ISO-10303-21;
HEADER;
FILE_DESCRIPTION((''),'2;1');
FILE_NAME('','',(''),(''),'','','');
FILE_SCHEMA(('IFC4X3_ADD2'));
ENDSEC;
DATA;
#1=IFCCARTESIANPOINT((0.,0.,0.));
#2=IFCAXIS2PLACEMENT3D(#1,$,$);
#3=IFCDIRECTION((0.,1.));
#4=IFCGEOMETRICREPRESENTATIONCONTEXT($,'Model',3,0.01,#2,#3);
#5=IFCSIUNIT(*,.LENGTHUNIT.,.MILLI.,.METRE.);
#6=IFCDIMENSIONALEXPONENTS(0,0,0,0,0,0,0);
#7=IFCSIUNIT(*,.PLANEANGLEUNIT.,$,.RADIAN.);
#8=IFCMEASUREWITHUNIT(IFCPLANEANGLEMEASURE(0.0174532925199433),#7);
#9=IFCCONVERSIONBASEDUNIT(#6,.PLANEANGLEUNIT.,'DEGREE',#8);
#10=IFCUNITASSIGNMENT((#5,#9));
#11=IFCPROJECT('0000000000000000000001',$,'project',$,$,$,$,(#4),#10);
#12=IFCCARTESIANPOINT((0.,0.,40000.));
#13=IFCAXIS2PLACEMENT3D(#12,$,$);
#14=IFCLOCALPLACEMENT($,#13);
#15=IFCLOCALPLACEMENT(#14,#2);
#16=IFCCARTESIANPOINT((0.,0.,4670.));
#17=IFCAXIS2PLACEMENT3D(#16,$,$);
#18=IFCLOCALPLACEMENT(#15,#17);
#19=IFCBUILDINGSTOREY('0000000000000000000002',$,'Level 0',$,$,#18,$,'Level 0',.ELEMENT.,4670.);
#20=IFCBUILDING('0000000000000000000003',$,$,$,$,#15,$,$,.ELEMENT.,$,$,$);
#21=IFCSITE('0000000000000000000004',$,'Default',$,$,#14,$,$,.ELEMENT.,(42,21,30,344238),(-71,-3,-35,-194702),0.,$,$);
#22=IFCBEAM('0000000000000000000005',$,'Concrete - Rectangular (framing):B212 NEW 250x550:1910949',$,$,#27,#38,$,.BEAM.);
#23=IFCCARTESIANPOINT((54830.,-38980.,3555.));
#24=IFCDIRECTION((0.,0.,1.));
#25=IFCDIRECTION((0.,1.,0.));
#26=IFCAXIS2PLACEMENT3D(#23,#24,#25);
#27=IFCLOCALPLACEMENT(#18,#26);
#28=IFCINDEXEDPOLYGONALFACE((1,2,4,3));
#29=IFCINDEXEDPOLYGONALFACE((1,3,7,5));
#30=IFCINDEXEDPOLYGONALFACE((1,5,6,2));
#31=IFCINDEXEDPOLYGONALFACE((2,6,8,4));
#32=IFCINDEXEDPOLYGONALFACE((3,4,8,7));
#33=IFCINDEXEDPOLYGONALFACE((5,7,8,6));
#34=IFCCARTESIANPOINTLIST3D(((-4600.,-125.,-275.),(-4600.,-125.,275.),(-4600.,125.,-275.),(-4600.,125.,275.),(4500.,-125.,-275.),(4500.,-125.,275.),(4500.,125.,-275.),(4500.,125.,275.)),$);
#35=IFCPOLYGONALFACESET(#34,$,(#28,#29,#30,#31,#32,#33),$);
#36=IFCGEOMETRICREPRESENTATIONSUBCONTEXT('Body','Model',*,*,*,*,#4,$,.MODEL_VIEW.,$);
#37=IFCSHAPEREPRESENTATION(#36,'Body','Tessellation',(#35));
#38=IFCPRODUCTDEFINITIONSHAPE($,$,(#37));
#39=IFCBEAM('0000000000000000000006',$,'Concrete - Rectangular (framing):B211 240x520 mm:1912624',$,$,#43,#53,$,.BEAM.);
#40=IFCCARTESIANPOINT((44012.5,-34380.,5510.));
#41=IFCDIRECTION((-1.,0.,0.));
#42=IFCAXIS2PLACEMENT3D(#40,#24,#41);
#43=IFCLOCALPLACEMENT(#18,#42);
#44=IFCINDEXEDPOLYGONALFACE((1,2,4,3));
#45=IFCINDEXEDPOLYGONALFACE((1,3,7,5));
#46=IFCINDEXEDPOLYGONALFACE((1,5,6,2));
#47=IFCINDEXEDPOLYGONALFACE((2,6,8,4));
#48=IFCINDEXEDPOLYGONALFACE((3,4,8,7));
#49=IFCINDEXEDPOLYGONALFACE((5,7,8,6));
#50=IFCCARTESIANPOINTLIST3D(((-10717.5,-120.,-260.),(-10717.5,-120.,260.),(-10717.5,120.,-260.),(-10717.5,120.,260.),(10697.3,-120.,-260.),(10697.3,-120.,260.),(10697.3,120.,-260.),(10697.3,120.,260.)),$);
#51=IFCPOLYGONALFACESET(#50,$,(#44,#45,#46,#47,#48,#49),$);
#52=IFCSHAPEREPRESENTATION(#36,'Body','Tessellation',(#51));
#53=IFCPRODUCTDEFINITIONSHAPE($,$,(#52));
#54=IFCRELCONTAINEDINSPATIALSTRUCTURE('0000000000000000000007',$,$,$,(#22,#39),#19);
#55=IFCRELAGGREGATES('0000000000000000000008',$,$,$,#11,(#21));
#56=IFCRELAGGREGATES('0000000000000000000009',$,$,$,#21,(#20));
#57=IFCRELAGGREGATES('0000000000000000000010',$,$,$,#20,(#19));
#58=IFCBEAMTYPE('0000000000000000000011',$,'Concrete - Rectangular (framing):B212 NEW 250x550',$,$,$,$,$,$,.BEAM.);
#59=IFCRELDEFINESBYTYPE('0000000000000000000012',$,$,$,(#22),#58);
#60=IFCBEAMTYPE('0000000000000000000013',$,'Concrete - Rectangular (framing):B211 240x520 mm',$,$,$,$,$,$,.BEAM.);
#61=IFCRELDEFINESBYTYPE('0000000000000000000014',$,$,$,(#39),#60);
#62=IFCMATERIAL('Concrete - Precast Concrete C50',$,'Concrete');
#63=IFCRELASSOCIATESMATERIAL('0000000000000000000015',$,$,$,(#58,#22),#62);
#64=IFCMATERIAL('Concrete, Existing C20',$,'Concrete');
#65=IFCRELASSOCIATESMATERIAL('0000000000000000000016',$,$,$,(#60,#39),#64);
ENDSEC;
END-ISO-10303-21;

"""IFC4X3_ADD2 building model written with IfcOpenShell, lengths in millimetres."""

from ifc_helpers import new_model, entity, si_unit, converted_unit, direction, frame, origin, origin_2d_with_axis, place, context, subcontext, project, spatial, rectangle, extrude, source, transform, mapped, material, material_profile, profile_set, profile_usage, type_object, type_shapes, element, save


model = new_model("IFC4X3_ADD2")

# Units and contexts
model_context = context("Model", 3, precision=0.01, world=origin(), true_north=direction((0.0, 1.0)))
body_context = subcontext(model_context, "Body", "Model", "MODEL_VIEW")
ifc_project = project(units=[si_unit("LENGTHUNIT", "METRE", prefix="MILLI"), converted_unit("PLANEANGLEUNIT", "DEGREE", entity("IfcPlaneAngleMeasure", 0.0174532925199433), si_unit("PLANEANGLEUNIT", "RADIAN"), dimensions=[0, 0, 0, 0, 0, 0, 0])], contexts=[model_context])

# Site, building, storey
site_placement = place(None, frame((0.0, 0.0, 40000.0)))
site = spatial("IfcSite", under=ifc_project, at=site_placement, Name="Default", CompositionType="ELEMENT", RefLatitude=(42, 21, 30, 344238), RefLongitude=(-71, -3, -35, -194702), RefElevation=0.0)
building_placement = place(site_placement, origin())
building = spatial("IfcBuilding", under=site, at=building_placement, CompositionType="ELEMENT")
storey_placement = place(building_placement, frame((0.0, 0.0, 4670.0)))
storey = spatial("IfcBuildingStorey", under=building, at=storey_placement, Name="Level 0", LongName="Level 0", CompositionType="ELEMENT", Elevation=4670.0)

# Beams
ifc_material_1 = material(Name="Concrete - Precast Concrete C50", Category="Concrete")
ifc_material_profile_1 = material_profile(ifc_material_1, rectangle(XDim=9200.0, YDim=250.0, at=origin_2d_with_axis()), Name="B212 NEW 250x550")
ifc_profile_set_1 = profile_set([ifc_material_profile_1], Name="B212 NEW 250x550")
ifc_profile_usage_1 = profile_usage(ifc_profile_set_1, cardinal=8)
beam_type_1 = type_object("IfcBeamType", Name="Concrete - Rectangular (framing):B212 NEW 250x550", PredefinedType="BEAM", material=ifc_profile_set_1)
shared_shape_1 = source(origin(), body_context, "Body", "SweptSolid", [
    extrude(rectangle(XDim=9100.0, YDim=250.0, at=origin_2d_with_axis()), frame((-50.0, 0.0, -275.0), z_axis=(0.0, 0.0, 1.0), x_axis=(-1.0, 0.0, 0.0)), (0.0, 0.0, 1.0), 550.0),
])
type_shapes(beam_type_1, [shared_shape_1])
beam_1_placement = place(storey_placement, frame((54830.0, -38980.0, 3555.0), z_axis=(0.0, 0.0, 1.0), x_axis=(0.0, 1.0, 0.0)))
element("IfcBeam", 1, at=beam_1_placement, inside=storey, type_object=beam_type_1, material=ifc_profile_usage_1, Name="Concrete - Rectangular (framing):B212 NEW 250x550:1910949", PredefinedType="BEAM", context=body_context, shape_type="MappedRepresentation", body=[
    mapped(shared_shape_1, transform((0.0, 0.0, 0.0), scale=1.0)),
])
ifc_material_2 = material(Name="Concrete, Existing C20", Category="Concrete")
ifc_material_profile_2 = material_profile(ifc_material_2, rectangle(XDim=21339.8, YDim=240.0, at=origin_2d_with_axis()), Name="B211 240x520 mm")
ifc_profile_set_2 = profile_set([ifc_material_profile_2], Name="B211 240x520 mm")
ifc_profile_usage_2 = profile_usage(ifc_profile_set_2, cardinal=8)
beam_type_2 = type_object("IfcBeamType", Name="Concrete - Rectangular (framing):B211 240x520 mm", PredefinedType="BEAM", material=ifc_profile_set_2)
shared_shape_2 = source(origin(), body_context, "Body", "SweptSolid", [
    extrude(rectangle(XDim=21414.8, YDim=240.0, at=origin_2d_with_axis()), frame((-10.1, 0.0, -260.0), z_axis=(0.0, 0.0, 1.0), x_axis=(-1.0, 0.0, 0.0)), (0.0, 0.0, 1.0), 520.0),
])
type_shapes(beam_type_2, [shared_shape_2])
beam_2_placement = place(storey_placement, frame((44012.5, -34380.0, 5510.0), z_axis=(0.0, 0.0, 1.0), x_axis=(-1.0, 0.0, 0.0)))
element("IfcBeam", 2, at=beam_2_placement, inside=storey, type_object=beam_type_2, material=ifc_profile_usage_2, Name="Concrete - Rectangular (framing):B211 240x520 mm:1912624", PredefinedType="BEAM", context=body_context, shape_type="MappedRepresentation", body=[
    mapped(shared_shape_2, transform((0.0, 0.0, 0.0), scale=1.0)),
])

save(model, "model.ifc")
